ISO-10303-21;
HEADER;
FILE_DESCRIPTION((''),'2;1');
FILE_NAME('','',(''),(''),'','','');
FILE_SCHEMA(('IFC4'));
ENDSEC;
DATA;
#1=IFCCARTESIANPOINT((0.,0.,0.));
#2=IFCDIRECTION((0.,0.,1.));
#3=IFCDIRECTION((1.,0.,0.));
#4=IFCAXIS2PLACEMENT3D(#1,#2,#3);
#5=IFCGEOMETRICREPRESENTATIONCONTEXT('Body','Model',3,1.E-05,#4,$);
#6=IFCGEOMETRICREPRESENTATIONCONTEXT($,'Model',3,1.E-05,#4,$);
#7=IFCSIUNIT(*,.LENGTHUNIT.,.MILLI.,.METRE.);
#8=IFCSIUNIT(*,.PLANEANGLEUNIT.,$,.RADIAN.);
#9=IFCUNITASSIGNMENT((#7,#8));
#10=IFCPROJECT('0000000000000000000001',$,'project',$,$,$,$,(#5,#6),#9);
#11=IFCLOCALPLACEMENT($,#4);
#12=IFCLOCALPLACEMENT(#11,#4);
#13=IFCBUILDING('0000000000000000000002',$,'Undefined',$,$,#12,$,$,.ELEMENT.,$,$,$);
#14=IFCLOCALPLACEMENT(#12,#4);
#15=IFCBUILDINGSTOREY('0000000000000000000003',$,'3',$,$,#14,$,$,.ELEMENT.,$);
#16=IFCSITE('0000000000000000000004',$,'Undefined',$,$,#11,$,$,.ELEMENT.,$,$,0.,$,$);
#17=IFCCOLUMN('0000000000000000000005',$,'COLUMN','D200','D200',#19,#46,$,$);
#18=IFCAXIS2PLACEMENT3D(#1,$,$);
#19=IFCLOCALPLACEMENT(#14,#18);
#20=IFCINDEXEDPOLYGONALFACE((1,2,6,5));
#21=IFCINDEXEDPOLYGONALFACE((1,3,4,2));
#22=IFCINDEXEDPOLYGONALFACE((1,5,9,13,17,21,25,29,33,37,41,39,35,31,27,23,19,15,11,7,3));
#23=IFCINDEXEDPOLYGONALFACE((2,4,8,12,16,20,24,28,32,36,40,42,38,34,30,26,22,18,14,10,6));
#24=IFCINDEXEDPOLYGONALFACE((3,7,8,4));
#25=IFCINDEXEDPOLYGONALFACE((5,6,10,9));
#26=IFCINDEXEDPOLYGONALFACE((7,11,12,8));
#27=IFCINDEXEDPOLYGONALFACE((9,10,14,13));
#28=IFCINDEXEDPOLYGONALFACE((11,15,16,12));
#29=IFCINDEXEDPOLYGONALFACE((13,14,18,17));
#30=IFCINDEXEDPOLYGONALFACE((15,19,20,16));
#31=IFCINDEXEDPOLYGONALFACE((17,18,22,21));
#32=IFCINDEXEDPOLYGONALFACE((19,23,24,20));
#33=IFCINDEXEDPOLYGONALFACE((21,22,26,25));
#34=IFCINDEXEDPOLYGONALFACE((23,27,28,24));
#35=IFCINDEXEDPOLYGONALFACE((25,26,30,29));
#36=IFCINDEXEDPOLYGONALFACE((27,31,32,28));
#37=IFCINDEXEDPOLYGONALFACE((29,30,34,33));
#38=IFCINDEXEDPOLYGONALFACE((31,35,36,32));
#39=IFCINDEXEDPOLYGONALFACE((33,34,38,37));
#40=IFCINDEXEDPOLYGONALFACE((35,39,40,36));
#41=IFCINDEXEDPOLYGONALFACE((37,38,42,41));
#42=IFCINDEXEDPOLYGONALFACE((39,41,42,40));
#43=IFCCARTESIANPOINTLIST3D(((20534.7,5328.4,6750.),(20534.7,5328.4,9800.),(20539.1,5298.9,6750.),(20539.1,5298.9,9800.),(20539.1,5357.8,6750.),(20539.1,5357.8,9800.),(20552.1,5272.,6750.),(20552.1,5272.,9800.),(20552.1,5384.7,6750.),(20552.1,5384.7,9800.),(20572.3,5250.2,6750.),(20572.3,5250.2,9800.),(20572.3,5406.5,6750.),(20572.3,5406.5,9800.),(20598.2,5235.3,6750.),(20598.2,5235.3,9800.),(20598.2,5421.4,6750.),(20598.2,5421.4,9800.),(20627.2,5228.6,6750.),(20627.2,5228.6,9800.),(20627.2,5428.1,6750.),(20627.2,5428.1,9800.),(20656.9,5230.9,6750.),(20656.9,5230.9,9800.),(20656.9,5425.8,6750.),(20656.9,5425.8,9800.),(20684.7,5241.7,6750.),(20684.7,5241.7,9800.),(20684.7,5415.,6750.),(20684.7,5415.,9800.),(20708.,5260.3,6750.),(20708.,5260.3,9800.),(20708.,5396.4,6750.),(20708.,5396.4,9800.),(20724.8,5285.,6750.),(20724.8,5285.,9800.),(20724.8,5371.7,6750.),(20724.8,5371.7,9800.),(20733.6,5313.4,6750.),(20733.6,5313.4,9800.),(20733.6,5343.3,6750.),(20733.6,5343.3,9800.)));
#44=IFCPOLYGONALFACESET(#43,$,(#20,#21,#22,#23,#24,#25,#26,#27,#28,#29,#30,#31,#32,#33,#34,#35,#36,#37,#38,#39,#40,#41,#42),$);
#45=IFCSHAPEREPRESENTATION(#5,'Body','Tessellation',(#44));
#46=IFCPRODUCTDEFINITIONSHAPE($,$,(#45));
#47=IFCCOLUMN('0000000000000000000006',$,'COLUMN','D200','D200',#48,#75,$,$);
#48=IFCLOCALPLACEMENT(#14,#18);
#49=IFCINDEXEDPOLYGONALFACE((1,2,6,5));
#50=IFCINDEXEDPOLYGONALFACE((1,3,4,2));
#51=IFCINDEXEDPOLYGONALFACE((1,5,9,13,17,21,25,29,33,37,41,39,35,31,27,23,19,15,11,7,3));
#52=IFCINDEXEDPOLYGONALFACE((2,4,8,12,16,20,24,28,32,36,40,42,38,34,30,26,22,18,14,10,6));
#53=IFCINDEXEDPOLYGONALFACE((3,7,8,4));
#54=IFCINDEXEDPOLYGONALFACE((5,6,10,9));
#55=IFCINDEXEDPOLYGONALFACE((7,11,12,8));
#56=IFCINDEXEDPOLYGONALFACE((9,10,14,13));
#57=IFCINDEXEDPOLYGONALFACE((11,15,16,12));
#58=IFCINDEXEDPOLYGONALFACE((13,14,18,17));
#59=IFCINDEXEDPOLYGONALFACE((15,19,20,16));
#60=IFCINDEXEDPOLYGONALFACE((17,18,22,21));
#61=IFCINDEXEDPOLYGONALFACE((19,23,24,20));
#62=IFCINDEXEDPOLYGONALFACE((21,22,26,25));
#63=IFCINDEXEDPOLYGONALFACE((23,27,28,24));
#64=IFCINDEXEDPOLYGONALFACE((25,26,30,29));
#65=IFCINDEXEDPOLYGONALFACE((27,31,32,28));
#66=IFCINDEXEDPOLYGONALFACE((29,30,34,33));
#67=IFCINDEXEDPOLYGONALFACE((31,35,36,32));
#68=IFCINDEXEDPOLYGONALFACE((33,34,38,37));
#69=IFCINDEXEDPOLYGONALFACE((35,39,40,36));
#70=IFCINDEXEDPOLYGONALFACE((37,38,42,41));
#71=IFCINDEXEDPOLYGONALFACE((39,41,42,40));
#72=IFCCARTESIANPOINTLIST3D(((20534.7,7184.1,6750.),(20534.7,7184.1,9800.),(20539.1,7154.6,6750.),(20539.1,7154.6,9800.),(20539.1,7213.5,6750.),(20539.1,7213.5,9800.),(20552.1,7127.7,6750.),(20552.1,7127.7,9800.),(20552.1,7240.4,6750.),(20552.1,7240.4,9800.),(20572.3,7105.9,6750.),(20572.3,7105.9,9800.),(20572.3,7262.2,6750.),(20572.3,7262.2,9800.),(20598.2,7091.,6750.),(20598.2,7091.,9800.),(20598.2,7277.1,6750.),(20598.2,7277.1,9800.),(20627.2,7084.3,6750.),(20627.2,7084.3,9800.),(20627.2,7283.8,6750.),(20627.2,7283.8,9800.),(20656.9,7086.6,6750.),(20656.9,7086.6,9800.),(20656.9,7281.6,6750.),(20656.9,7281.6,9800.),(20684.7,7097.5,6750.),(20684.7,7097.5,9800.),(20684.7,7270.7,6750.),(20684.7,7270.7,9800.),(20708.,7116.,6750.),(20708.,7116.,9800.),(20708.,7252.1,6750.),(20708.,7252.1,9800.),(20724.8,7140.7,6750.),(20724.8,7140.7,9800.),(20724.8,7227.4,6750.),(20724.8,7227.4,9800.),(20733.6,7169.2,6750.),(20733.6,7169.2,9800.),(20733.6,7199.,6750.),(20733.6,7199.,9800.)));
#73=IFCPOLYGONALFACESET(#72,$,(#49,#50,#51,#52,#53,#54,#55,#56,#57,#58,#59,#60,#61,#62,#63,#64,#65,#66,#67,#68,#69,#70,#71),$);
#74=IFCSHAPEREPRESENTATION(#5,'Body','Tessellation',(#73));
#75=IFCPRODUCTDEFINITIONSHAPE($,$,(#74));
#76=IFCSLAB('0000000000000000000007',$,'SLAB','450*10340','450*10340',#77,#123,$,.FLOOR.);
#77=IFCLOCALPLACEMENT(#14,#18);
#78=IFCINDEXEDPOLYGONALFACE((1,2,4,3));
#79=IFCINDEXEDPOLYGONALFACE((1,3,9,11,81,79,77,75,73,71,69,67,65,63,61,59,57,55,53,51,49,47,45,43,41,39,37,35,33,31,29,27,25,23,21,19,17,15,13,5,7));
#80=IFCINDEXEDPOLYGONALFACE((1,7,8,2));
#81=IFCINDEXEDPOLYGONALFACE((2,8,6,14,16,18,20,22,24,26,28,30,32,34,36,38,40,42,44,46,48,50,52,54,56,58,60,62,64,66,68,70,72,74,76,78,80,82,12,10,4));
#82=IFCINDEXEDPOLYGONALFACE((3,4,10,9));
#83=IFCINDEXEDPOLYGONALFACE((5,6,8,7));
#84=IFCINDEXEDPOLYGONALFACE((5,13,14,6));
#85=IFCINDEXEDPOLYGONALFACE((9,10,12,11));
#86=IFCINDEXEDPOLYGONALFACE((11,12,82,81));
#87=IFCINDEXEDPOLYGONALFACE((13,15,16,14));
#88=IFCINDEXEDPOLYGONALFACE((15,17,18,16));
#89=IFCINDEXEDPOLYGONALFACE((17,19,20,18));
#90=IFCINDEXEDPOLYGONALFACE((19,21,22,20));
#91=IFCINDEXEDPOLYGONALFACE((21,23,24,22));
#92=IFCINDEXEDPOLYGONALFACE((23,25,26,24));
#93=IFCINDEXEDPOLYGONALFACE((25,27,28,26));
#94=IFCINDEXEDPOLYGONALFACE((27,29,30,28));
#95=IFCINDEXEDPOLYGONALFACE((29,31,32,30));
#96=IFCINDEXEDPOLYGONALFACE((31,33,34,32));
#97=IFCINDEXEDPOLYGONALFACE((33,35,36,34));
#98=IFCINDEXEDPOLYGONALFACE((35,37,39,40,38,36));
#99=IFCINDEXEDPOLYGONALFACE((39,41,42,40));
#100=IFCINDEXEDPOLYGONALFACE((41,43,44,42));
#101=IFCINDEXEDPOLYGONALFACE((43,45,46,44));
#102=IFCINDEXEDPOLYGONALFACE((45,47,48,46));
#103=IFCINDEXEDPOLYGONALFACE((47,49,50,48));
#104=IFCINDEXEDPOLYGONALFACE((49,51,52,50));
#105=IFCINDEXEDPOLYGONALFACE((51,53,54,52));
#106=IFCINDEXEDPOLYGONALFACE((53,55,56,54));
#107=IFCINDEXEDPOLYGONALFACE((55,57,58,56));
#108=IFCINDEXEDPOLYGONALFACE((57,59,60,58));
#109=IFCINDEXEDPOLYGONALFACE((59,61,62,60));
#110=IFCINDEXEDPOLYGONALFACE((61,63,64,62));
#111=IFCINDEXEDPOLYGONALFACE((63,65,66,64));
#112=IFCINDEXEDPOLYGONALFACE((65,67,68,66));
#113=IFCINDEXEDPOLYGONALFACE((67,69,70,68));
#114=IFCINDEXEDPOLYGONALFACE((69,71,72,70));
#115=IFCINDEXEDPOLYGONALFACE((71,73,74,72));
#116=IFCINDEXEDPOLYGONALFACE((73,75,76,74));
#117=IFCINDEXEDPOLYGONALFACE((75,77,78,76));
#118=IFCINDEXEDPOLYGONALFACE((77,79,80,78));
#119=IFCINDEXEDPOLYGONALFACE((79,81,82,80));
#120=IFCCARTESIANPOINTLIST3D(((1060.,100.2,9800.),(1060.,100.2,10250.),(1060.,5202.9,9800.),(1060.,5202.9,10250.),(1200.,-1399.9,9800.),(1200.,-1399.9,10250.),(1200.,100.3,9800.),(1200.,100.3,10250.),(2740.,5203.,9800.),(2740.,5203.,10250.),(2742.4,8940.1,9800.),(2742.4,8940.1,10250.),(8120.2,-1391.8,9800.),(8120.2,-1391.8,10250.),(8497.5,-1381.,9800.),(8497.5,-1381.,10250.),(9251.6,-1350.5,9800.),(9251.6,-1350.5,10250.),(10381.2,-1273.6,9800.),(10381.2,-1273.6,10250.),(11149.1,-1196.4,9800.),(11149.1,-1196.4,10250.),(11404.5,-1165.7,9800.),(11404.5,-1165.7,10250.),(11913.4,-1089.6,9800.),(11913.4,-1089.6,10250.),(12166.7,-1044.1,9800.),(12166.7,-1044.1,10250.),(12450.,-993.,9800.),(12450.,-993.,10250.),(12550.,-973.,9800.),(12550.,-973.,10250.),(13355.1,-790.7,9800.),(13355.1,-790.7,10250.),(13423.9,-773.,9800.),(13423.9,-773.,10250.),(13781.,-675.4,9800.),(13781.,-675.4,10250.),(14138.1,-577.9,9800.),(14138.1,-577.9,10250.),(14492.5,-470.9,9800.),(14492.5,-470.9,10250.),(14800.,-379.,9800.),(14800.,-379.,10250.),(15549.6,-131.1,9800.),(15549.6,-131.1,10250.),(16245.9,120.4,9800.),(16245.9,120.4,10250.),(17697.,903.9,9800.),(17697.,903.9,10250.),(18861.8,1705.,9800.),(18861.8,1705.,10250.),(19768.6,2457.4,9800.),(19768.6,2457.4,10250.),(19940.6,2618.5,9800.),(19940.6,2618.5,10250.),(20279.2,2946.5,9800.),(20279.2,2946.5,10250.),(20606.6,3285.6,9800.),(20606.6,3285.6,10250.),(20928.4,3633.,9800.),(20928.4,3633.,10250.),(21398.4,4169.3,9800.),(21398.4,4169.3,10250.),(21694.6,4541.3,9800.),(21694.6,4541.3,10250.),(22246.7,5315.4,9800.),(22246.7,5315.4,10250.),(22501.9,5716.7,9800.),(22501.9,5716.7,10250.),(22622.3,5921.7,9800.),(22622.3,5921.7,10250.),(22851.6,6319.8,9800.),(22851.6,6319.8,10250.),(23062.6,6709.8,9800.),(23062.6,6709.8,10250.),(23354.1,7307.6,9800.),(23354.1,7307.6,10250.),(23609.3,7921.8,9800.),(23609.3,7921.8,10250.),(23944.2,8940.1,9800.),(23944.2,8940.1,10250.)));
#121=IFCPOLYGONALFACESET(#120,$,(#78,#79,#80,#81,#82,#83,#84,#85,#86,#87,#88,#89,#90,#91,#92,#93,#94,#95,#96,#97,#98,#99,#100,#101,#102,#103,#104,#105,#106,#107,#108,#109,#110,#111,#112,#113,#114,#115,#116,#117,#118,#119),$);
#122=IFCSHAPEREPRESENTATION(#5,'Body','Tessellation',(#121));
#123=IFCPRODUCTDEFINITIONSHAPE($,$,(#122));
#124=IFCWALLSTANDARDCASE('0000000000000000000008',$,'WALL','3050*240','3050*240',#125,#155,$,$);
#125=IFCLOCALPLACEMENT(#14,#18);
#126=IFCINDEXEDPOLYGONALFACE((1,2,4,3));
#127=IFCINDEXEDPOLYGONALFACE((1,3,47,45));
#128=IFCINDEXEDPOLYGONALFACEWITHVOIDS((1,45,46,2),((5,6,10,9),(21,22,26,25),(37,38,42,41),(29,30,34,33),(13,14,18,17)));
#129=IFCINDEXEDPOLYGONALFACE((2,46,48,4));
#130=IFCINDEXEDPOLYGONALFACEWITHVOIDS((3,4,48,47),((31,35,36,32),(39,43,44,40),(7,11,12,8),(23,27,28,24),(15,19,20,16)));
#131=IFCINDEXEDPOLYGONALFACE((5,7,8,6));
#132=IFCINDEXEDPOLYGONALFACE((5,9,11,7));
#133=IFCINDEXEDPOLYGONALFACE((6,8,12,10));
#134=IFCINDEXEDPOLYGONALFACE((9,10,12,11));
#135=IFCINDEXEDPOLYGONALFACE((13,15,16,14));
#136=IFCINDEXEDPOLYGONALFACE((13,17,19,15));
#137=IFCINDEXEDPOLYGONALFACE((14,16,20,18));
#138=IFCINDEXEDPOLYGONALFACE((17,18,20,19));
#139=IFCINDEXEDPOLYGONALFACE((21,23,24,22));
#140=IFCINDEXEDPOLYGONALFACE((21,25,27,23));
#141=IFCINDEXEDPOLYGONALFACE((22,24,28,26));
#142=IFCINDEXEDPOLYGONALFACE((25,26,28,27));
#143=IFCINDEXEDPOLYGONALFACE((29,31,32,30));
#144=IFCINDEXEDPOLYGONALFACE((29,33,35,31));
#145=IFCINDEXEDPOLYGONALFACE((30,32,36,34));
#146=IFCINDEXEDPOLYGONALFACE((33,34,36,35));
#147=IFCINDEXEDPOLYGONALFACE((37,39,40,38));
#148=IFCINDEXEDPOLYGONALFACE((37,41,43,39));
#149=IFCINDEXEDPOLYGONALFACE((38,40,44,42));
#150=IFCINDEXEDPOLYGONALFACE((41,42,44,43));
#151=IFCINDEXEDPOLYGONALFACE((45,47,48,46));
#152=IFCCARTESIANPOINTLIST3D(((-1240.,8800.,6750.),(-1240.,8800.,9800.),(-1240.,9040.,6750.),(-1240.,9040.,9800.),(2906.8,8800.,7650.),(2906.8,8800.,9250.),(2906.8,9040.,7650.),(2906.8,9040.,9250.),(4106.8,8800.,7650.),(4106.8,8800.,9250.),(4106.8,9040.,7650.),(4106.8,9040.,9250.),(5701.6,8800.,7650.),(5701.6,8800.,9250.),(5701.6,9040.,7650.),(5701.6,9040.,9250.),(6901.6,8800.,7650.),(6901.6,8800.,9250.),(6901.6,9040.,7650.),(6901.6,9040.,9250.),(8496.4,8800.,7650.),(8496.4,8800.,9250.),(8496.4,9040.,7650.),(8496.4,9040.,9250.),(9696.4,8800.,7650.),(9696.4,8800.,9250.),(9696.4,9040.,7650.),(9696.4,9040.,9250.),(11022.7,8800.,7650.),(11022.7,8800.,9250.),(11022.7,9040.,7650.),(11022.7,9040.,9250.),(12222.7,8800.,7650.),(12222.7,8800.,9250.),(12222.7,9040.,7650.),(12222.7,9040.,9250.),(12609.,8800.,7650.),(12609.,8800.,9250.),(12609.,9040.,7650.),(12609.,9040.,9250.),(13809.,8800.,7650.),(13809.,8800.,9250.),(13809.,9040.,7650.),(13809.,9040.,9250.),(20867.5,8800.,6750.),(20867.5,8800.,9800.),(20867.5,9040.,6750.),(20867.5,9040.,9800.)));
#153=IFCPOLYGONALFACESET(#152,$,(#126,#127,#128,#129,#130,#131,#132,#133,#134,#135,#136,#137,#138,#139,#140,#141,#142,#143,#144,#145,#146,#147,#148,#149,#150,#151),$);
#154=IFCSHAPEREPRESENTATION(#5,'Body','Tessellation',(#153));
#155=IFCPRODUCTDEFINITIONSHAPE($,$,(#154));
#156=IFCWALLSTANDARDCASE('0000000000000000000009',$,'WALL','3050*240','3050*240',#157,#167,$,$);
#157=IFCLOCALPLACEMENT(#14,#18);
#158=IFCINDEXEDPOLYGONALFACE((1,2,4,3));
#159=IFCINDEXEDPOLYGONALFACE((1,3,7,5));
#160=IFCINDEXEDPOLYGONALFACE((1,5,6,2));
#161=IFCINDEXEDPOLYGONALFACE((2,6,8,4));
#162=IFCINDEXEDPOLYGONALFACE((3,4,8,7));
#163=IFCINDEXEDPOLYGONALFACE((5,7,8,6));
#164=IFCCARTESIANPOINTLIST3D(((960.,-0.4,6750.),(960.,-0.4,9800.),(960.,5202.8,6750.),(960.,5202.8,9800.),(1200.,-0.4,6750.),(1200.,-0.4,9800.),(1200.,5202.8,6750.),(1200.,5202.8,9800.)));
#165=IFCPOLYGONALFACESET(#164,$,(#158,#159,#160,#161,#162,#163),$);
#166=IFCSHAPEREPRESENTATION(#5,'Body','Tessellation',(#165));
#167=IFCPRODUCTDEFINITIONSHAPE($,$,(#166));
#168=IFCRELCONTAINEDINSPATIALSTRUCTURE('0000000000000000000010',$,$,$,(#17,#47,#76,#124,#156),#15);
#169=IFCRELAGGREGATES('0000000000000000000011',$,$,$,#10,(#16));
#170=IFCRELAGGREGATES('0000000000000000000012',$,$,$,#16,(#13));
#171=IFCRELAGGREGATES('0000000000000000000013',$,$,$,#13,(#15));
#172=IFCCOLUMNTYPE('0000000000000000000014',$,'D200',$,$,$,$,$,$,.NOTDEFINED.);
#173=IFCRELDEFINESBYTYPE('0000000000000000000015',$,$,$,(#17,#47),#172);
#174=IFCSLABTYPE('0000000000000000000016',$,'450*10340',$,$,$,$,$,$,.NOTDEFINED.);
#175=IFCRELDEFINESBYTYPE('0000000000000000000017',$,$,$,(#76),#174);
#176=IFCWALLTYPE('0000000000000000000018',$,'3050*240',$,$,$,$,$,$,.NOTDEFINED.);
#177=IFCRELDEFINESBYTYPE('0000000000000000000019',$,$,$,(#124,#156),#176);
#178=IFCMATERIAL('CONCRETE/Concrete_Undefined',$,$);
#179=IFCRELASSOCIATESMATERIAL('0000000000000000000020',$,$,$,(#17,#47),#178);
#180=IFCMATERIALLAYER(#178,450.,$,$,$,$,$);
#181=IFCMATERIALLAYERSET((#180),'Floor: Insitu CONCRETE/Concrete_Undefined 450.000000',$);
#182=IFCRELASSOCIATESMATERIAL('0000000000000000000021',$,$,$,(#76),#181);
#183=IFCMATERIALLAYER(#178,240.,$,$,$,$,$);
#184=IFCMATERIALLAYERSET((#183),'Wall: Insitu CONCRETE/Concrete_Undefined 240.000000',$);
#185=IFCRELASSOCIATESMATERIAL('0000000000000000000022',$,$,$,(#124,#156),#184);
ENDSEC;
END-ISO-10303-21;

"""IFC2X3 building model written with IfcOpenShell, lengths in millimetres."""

from ifc_helpers import new_model, si_unit, frame, frame_2d, origin_with_axes, origin_2d_with_axis, place, context, project, spatial, polyline, rectangle, circle, outline, extrude, material, layer, layer_set, layer_usage, type_object, element, save


model = new_model("IFC2X3")

# Units and contexts
model_context_1 = context("Model", 3, precision=1e-05, world=origin_with_axes(), identifier="Body")
model_context_2 = context("Model", 3, precision=1e-05, world=origin_with_axes())
ifc_project = project(units=[si_unit("LENGTHUNIT", "METRE", prefix="MILLI"), si_unit("PLANEANGLEUNIT", "RADIAN")], contexts=[model_context_1, model_context_2])

# Site, building, storey
site_placement = place(None, origin_with_axes())
site = spatial("IfcSite", under=ifc_project, at=site_placement, Name="Undefined", CompositionType="ELEMENT", RefElevation=0.0)
building_placement = place(site_placement, origin_with_axes())
building = spatial("IfcBuilding", under=site, at=building_placement, Name="Undefined", CompositionType="ELEMENT")
storey_placement = place(building_placement, origin_with_axes())
storey = spatial("IfcBuildingStorey", under=building, at=storey_placement, Name="3", CompositionType="ELEMENT")

# Columns
ifc_material = material(Name="CONCRETE/Concrete_Undefined")
column_type = type_object("IfcColumnType", Name="D200", PredefinedType="NOTDEFINED")
for number, where, z_axis, x_axis, name in (
    (1, (20634.7, 5328.4, 6750.0), (0.0, 0.0, 1.0), (1.0, 0.0, 0.0), "COLUMN"),
    (2, (20634.7, 7184.1, 6750.0), (0.0, 0.0, 1.0), (1.0, 0.0, 0.0), "COLUMN"),
):
    element("IfcColumn", number, at=place(storey_placement, frame(where, z_axis=z_axis, x_axis=x_axis)), inside=storey, type_object=column_type, material=ifc_material, Name=name, Description="D200", ObjectType="D200", context=model_context_1, shape_type="SweptSolid", body=[
        extrude(circle(Radius=100.0, at=origin_2d_with_axis()), frame((0.0, 0.0, 3050.0), z_axis=(0.0, 0.0, -1.0), x_axis=(-1.0, 0.0, 0.0)), (0.0, 0.0, 1.0), 3050.0),
    ])

# Slab
ifc_layer_1 = layer(ifc_material, 450.0)
ifc_layer_set_1 = layer_set([ifc_layer_1], Name="Floor: Insitu CONCRETE/Concrete_Undefined 450.000000")
ifc_layer_usage_1 = layer_usage(ifc_layer_set_1, "AXIS3", "POSITIVE", -225.0)
slab_type_1 = type_object("IfcSlabType", Name="450*10340", PredefinedType="NOTDEFINED")
slab_1_placement = place(storey_placement, frame((23944.2, 8940.1, 10025.0), z_axis=(0.0, 0.0, 1.0), x_axis=(-1.0, 0.0, 0.0)))
element("IfcSlab", 3, at=slab_1_placement, inside=storey, type_object=slab_type_1, material=ifc_layer_usage_1, Name="SLAB", Description="450*10340", ObjectType="450*10340", PredefinedType="FLOOR", context=model_context_1, shape_type="SweptSolid", body=[
    extrude(outline(polyline([(0.0, 0.0), (21201.9, 0.0), (21204.2, 3737.1), (22884.2, 3737.1), (22884.3, 8839.9), (22744.3, 8839.7), (22744.3, 10340.0), (15824.0, 10331.9), (15446.8, 10321.1), (14692.6, 10290.5), (13563.1, 10213.6), (12795.2, 10136.5), (12539.7, 10105.8), (12030.8, 10029.7), (11777.6, 9984.2), (11494.3, 9933.0), (11394.3, 9913.1), (10589.1, 9730.8), (10520.3, 9713.1), (10163.3, 9615.5), (9806.2, 9518.0), (9451.8, 9411.0), (9144.3, 9319.1), (8394.6, 9071.1), (7698.3, 8819.7), (6247.2, 8036.2), (5082.4, 7235.1), (4175.7, 6482.7), (4003.6, 6321.5), (3665.0, 5993.6), (3337.6, 5654.5), (3015.8, 5307.1), (2545.8, 4770.8), (2249.6, 4398.8), (1697.6, 3624.6), (1442.4, 3223.4), (1322.0, 3018.4), (1092.6, 2620.3), (881.7, 2230.3), (590.1, 1632.5), (334.9, 1018.3), (0.0, 0.0)])), frame((0.0, 0.0, -225.0), z_axis=(0.0, 0.0, 1.0), x_axis=(1.0, 0.0, 0.0)), (0.0, 0.0, 1.0), 450.0),
])

# Wall, openings
ifc_layer_2 = layer(ifc_material, 240.0)
ifc_layer_set_2 = layer_set([ifc_layer_2], Name="Wall: Insitu CONCRETE/Concrete_Undefined 240.000000")
ifc_layer_usage_2 = layer_usage(ifc_layer_set_2, "AXIS2", "POSITIVE", -120.0)
wall_type_1 = type_object("IfcWallType", Name="3050*240", PredefinedType="NOTDEFINED")
wall_1_placement = place(storey_placement, frame((20867.5, 8920.0, 6750.0), z_axis=(0.0, 0.0, 1.0), x_axis=(-1.0, 0.0, 0.0)))
wall_1 = element("IfcWallStandardCase", 4, at=wall_1_placement, inside=storey, type_object=wall_type_1, material=ifc_layer_usage_2, Name="WALL", Description="3050*240", ObjectType="3050*240", context=model_context_1, shape_type="SweptSolid", body=[
    extrude(rectangle(XDim=22107.5, YDim=240.0, at=frame_2d((0.0, 11053.8), x_axis=(0.0, -1.0))), frame((0.0, 0.0, 0.0), z_axis=(0.0, 0.0, 1.0), x_axis=(0.0, -1.0, 0.0)), (0.0, 0.0, 1.0), 3050.0),
])
opening_1_placement = place(storey_placement, frame((20867.5, 8920.0, 6750.0), z_axis=(0.0, 0.0, 1.0), x_axis=(-1.0, 0.0, 0.0)))
element("IfcOpeningElement", 5, at=opening_1_placement, cuts=wall_1, ObjectType="Recess", context=model_context_1, shape_type="SweptSolid", body=[
    extrude(outline(polyline([(0.0, 0.0), (1200.0, 0.0), (1200.0, 1600.0), (0.0, 1600.0), (0.0, 0.0)])), frame((7058.5, -122.5, 2500.0), z_axis=(0.0, 1.0, 0.0), x_axis=(1.0, 0.0, 0.0)), (0.0, 0.0, 1.0), 245.0),
])
opening_2_placement = place(storey_placement, frame((20867.5, 8920.0, 6750.0), z_axis=(0.0, 0.0, 1.0), x_axis=(-1.0, 0.0, 0.0)))
element("IfcOpeningElement", 6, at=opening_2_placement, cuts=wall_1, ObjectType="Recess", context=model_context_1, shape_type="SweptSolid", body=[
    extrude(outline(polyline([(0.0, 0.0), (1600.0, 0.0), (1600.0, 1200.0), (0.0, 1200.0), (0.0, 0.0)])), frame((8644.8, 122.5, 2500.0), z_axis=(0.0, -1.0, 0.0), x_axis=(0.0, 0.0, -1.0)), (0.0, 0.0, 1.0), 245.0),
])
opening_3_placement = place(storey_placement, frame((20867.5, 8920.0, 6750.0), z_axis=(0.0, 0.0, 1.0), x_axis=(-1.0, 0.0, 0.0)))
element("IfcOpeningElement", 7, at=opening_3_placement, cuts=wall_1, ObjectType="Recess", context=model_context_1, shape_type="SweptSolid", body=[
    extrude(outline(polyline([(0.0, 0.0), (1200.0, 0.0), (1200.0, 1600.0), (0.0, 1600.0), (0.0, 0.0)])), frame((11171.2, -122.5, 2500.0), z_axis=(0.0, 1.0, 0.0), x_axis=(1.0, 0.0, 0.0)), (0.0, 0.0, 1.0), 245.0),
])
opening_4_placement = place(storey_placement, frame((20867.5, 8920.0, 6750.0), z_axis=(0.0, 0.0, 1.0), x_axis=(-1.0, 0.0, 0.0)))
element("IfcOpeningElement", 8, at=opening_4_placement, cuts=wall_1, ObjectType="Recess", context=model_context_1, shape_type="SweptSolid", body=[
    extrude(outline(polyline([(0.0, 0.0), (1200.0, 0.0), (1200.0, 1600.0), (0.0, 1600.0), (0.0, 0.0)])), frame((13966.0, -122.5, 2500.0), z_axis=(0.0, 1.0, 0.0), x_axis=(1.0, 0.0, 0.0)), (0.0, 0.0, 1.0), 245.0),
])
opening_5_placement = place(storey_placement, frame((20867.5, 8920.0, 6750.0), z_axis=(0.0, 0.0, 1.0), x_axis=(-1.0, 0.0, 0.0)))
element("IfcOpeningElement", 9, at=opening_5_placement, cuts=wall_1, ObjectType="Recess", context=model_context_1, shape_type="SweptSolid", body=[
    extrude(outline(polyline([(0.0, 0.0), (1600.0, 0.0), (1600.0, 1200.0), (0.0, 1200.0), (0.0, 0.0)])), frame((16760.7, 122.5, 2500.0), z_axis=(0.0, -1.0, 0.0), x_axis=(0.0, 0.0, -1.0)), (0.0, 0.0, 1.0), 245.0),
])

# Wall
ifc_layer_usage_3 = layer_usage(ifc_layer_set_2, "AXIS2", "POSITIVE", -120.0)
wall_2_placement = place(storey_placement, frame((1080.0, -0.4, 6750.0), z_axis=(0.0, 0.0, 1.0), x_axis=(0.0, 1.0, 0.0)))
element("IfcWallStandardCase", 10, at=wall_2_placement, inside=storey, type_object=wall_type_1, material=ifc_layer_usage_3, Name="WALL", Description="3050*240", ObjectType="3050*240", context=model_context_1, shape_type="SweptSolid", body=[
    extrude(rectangle(XDim=5203.2, YDim=240.0, at=frame_2d((0.0, 2601.6), x_axis=(0.0, -1.0))), frame((0.0, 0.0, 0.0), z_axis=(0.0, 0.0, 1.0), x_axis=(0.0, -1.0, 0.0)), (0.0, 0.0, 1.0), 3050.0),
])

save(model, "model.ifc")
